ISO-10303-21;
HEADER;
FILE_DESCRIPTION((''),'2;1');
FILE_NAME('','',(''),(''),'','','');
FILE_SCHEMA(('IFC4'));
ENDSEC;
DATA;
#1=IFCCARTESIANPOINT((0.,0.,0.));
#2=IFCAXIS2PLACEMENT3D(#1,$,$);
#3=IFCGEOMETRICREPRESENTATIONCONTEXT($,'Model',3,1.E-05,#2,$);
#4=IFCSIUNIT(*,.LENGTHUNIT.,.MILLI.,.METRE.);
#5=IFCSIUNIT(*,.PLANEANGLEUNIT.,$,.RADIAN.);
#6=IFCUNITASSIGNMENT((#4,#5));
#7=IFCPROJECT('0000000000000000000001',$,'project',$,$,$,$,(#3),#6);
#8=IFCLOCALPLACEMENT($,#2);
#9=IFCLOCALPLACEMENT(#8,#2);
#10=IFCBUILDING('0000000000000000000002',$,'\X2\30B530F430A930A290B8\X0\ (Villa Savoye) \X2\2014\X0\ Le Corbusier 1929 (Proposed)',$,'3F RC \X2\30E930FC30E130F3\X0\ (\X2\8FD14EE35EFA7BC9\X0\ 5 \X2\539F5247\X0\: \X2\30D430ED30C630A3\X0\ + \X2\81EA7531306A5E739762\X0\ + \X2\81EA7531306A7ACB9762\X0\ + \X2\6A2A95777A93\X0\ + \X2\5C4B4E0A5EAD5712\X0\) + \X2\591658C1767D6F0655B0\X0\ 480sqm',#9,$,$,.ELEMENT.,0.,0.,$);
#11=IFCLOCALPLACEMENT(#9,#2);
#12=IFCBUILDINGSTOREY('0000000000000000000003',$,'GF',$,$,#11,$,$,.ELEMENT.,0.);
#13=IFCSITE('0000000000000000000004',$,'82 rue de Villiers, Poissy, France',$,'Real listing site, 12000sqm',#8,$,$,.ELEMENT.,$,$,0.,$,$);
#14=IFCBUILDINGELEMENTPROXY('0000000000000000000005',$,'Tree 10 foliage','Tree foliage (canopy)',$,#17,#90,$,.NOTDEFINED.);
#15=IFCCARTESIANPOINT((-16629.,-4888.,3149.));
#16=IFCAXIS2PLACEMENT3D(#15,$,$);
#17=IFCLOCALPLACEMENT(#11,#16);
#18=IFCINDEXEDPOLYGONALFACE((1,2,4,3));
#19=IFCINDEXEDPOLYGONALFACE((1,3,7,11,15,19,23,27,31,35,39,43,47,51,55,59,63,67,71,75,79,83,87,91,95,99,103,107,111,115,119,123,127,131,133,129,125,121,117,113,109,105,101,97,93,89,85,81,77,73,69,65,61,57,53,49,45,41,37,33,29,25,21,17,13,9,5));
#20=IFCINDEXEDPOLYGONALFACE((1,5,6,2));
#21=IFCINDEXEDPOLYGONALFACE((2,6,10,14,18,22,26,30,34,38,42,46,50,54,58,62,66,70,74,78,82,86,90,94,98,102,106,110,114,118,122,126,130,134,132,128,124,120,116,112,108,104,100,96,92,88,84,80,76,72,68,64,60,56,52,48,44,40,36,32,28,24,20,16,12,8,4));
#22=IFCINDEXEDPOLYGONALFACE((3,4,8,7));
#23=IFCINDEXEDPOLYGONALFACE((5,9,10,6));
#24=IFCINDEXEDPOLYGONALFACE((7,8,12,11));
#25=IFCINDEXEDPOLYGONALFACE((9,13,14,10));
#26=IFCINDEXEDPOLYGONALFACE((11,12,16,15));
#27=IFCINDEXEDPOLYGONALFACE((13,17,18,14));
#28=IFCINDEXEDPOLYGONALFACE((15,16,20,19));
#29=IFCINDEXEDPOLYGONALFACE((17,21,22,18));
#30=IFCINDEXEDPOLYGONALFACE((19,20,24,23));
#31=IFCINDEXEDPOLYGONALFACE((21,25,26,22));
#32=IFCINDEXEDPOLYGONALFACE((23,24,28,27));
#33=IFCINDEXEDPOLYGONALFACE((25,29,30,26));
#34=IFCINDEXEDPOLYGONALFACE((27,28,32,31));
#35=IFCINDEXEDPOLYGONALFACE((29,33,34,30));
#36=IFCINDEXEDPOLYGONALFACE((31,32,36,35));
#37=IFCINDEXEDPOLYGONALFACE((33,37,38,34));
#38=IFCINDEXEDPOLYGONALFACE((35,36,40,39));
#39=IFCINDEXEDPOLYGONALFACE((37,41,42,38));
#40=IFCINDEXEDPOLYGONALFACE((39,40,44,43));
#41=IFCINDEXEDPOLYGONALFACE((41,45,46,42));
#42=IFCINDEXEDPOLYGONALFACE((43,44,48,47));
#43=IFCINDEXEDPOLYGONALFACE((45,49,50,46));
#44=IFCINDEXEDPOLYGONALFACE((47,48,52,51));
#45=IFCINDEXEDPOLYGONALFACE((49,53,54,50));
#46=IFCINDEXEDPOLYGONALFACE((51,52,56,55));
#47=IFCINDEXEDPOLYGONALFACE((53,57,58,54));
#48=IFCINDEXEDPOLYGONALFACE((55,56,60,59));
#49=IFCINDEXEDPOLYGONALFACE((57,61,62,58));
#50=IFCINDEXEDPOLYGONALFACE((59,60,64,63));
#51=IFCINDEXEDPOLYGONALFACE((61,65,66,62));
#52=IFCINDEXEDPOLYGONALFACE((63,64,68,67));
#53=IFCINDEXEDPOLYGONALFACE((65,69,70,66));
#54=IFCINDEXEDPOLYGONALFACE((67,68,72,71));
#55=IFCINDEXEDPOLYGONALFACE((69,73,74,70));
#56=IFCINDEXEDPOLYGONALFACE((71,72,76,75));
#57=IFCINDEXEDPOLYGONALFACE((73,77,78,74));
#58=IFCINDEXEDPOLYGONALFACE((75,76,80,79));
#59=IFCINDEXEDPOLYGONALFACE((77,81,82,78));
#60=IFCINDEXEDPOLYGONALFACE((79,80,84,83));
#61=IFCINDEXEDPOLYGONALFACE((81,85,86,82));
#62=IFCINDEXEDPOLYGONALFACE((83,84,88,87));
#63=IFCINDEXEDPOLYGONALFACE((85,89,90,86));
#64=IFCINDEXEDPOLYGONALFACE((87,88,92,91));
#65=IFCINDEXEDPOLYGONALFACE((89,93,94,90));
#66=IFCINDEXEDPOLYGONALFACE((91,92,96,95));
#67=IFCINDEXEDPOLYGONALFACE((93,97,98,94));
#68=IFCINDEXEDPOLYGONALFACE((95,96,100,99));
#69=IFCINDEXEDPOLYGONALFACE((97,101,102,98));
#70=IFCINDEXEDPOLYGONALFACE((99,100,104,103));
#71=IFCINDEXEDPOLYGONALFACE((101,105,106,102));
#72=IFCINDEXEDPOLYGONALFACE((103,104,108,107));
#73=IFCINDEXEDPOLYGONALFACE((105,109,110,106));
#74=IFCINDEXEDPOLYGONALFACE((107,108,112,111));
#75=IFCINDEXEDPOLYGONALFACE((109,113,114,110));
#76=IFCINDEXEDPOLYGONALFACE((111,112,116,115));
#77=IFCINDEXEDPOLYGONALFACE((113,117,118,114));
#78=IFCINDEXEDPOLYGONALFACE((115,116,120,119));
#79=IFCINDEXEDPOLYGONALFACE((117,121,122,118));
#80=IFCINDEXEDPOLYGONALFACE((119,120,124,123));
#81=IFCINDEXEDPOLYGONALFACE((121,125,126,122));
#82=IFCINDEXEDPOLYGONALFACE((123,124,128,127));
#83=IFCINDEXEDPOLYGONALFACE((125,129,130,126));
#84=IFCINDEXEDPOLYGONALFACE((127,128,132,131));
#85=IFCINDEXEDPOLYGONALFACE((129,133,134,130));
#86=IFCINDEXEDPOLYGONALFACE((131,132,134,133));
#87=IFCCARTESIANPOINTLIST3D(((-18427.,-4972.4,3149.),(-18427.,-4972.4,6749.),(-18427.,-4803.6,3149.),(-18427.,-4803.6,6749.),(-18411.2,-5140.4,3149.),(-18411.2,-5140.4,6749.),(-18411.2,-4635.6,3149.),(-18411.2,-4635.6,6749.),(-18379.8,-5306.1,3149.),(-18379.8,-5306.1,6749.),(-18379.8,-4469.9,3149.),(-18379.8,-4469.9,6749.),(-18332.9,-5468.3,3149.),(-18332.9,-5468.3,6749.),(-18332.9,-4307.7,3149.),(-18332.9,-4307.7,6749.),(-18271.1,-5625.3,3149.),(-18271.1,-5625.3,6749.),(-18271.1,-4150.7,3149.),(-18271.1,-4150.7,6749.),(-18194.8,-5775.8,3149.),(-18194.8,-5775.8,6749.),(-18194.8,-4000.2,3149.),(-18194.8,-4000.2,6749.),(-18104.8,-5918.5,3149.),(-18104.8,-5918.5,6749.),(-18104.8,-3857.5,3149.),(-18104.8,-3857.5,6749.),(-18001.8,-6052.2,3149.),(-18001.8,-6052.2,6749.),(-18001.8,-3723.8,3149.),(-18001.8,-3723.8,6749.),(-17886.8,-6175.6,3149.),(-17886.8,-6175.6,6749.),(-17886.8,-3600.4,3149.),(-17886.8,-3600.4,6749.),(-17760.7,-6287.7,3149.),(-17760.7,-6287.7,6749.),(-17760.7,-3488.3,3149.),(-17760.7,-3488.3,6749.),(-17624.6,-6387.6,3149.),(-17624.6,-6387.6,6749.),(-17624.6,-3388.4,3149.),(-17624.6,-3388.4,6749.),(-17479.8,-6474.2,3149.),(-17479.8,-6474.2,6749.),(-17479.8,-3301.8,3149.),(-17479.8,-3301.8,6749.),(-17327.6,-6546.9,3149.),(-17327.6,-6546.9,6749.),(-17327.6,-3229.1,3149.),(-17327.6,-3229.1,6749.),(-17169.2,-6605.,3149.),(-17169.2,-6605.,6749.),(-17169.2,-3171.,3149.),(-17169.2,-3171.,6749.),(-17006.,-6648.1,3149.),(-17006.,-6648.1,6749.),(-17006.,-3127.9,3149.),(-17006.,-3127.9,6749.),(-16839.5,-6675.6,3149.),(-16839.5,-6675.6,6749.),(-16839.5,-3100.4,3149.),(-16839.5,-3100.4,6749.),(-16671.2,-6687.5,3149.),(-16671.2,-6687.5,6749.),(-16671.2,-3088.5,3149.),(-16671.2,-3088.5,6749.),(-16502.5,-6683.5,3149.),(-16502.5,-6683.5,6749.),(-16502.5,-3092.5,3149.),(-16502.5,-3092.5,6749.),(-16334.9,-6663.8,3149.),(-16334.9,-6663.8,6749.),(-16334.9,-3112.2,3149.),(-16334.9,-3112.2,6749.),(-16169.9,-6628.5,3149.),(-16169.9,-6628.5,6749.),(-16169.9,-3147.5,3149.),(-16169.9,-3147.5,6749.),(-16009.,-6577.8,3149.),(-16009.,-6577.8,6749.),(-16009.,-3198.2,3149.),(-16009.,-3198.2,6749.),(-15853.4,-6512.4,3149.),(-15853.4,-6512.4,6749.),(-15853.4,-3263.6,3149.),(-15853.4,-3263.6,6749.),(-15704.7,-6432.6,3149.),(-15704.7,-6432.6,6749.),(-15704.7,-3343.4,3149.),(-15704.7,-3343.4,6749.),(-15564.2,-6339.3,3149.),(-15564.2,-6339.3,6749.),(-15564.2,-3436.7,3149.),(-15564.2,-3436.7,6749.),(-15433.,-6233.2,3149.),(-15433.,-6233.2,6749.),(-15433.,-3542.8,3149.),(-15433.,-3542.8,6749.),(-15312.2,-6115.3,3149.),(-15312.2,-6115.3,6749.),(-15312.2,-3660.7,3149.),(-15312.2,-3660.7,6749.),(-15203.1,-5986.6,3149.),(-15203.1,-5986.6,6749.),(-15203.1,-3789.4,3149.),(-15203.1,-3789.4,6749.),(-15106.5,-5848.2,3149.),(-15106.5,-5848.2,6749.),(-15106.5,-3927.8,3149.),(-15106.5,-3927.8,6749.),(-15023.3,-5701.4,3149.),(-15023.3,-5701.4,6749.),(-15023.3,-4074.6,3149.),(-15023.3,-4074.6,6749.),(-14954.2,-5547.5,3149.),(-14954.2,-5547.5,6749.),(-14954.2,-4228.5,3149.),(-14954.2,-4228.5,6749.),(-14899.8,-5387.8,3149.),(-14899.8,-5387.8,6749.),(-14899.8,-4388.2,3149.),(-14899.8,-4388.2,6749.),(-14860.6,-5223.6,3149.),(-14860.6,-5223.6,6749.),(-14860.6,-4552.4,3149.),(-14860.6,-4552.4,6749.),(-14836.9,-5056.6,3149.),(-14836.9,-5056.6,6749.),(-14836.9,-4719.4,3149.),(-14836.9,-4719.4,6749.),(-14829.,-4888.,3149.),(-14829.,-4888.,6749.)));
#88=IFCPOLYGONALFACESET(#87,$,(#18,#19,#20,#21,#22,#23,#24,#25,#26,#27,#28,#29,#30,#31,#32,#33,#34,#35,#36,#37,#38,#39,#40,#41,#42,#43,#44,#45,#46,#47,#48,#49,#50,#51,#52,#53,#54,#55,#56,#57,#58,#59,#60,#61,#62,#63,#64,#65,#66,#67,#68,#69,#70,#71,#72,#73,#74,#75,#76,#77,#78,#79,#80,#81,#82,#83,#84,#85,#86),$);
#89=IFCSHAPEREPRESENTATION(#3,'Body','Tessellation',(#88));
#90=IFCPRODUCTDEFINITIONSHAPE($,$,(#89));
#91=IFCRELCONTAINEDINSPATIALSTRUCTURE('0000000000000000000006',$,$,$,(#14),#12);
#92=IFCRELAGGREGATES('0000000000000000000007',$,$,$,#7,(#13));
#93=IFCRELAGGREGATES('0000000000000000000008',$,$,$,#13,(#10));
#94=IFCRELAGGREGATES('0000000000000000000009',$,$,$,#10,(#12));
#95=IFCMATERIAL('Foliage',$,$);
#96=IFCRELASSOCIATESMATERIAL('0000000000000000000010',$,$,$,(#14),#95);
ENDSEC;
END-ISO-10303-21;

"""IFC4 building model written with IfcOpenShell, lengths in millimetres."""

from ifc_helpers import new_model, si_unit, frame, origin, origin_2d, place, context, project, spatial, circle, extrude, material, element, save


model = new_model("IFC4")

# Units and contexts
model_context = context("Model", 3, precision=1e-05, world=origin())
ifc_project = project(units=[si_unit("LENGTHUNIT", "METRE", prefix="MILLI"), si_unit("PLANEANGLEUNIT", "RADIAN")], contexts=[model_context])

# Site, building, storey
site_placement = place(None, origin())
site = spatial("IfcSite", under=ifc_project, at=site_placement, Name="82 rue de Villiers, Poissy, France", ObjectType="Real listing site, 12000sqm", CompositionType="ELEMENT", RefElevation=0.0)
building_placement = place(site_placement, origin())
building = spatial("IfcBuilding", under=site, at=building_placement, Name="サヴォア邸 (Villa Savoye) — Le Corbusier 1929 (Proposed)", ObjectType="3F RC ラーメン (近代建築 5 原則: ピロティ + 自由な平面 + 自由な立面 + 横長窓 + 屋上庭園) + 外壁白漆喰 480sqm", CompositionType="ELEMENT", ElevationOfRefHeight=0.0, ElevationOfTerrain=0.0)
storey_placement = place(building_placement, origin())
storey = spatial("IfcBuildingStorey", under=building, at=storey_placement, Name="GF", CompositionType="ELEMENT", Elevation=0.0)

# Building element proxy
ifc_material_1 = material(Name="Foliage")
proxy_1_placement = place(storey_placement, frame((-16629.0, -4888.0, 3149.0)))
element("IfcBuildingElementProxy", 1, at=proxy_1_placement, inside=storey, material=ifc_material_1, Name="Tree 10 foliage", Description="Tree foliage (canopy)", PredefinedType="NOTDEFINED", context=model_context, shape_type="SweptSolid", body=[
    extrude(circle(Radius=1800.0, at=origin_2d()), frame((-16629.0, -4888.0, 3149.0)), (0.0, 0.0, 1.0), 3600.0),
])

save(model, "model.ifc")
